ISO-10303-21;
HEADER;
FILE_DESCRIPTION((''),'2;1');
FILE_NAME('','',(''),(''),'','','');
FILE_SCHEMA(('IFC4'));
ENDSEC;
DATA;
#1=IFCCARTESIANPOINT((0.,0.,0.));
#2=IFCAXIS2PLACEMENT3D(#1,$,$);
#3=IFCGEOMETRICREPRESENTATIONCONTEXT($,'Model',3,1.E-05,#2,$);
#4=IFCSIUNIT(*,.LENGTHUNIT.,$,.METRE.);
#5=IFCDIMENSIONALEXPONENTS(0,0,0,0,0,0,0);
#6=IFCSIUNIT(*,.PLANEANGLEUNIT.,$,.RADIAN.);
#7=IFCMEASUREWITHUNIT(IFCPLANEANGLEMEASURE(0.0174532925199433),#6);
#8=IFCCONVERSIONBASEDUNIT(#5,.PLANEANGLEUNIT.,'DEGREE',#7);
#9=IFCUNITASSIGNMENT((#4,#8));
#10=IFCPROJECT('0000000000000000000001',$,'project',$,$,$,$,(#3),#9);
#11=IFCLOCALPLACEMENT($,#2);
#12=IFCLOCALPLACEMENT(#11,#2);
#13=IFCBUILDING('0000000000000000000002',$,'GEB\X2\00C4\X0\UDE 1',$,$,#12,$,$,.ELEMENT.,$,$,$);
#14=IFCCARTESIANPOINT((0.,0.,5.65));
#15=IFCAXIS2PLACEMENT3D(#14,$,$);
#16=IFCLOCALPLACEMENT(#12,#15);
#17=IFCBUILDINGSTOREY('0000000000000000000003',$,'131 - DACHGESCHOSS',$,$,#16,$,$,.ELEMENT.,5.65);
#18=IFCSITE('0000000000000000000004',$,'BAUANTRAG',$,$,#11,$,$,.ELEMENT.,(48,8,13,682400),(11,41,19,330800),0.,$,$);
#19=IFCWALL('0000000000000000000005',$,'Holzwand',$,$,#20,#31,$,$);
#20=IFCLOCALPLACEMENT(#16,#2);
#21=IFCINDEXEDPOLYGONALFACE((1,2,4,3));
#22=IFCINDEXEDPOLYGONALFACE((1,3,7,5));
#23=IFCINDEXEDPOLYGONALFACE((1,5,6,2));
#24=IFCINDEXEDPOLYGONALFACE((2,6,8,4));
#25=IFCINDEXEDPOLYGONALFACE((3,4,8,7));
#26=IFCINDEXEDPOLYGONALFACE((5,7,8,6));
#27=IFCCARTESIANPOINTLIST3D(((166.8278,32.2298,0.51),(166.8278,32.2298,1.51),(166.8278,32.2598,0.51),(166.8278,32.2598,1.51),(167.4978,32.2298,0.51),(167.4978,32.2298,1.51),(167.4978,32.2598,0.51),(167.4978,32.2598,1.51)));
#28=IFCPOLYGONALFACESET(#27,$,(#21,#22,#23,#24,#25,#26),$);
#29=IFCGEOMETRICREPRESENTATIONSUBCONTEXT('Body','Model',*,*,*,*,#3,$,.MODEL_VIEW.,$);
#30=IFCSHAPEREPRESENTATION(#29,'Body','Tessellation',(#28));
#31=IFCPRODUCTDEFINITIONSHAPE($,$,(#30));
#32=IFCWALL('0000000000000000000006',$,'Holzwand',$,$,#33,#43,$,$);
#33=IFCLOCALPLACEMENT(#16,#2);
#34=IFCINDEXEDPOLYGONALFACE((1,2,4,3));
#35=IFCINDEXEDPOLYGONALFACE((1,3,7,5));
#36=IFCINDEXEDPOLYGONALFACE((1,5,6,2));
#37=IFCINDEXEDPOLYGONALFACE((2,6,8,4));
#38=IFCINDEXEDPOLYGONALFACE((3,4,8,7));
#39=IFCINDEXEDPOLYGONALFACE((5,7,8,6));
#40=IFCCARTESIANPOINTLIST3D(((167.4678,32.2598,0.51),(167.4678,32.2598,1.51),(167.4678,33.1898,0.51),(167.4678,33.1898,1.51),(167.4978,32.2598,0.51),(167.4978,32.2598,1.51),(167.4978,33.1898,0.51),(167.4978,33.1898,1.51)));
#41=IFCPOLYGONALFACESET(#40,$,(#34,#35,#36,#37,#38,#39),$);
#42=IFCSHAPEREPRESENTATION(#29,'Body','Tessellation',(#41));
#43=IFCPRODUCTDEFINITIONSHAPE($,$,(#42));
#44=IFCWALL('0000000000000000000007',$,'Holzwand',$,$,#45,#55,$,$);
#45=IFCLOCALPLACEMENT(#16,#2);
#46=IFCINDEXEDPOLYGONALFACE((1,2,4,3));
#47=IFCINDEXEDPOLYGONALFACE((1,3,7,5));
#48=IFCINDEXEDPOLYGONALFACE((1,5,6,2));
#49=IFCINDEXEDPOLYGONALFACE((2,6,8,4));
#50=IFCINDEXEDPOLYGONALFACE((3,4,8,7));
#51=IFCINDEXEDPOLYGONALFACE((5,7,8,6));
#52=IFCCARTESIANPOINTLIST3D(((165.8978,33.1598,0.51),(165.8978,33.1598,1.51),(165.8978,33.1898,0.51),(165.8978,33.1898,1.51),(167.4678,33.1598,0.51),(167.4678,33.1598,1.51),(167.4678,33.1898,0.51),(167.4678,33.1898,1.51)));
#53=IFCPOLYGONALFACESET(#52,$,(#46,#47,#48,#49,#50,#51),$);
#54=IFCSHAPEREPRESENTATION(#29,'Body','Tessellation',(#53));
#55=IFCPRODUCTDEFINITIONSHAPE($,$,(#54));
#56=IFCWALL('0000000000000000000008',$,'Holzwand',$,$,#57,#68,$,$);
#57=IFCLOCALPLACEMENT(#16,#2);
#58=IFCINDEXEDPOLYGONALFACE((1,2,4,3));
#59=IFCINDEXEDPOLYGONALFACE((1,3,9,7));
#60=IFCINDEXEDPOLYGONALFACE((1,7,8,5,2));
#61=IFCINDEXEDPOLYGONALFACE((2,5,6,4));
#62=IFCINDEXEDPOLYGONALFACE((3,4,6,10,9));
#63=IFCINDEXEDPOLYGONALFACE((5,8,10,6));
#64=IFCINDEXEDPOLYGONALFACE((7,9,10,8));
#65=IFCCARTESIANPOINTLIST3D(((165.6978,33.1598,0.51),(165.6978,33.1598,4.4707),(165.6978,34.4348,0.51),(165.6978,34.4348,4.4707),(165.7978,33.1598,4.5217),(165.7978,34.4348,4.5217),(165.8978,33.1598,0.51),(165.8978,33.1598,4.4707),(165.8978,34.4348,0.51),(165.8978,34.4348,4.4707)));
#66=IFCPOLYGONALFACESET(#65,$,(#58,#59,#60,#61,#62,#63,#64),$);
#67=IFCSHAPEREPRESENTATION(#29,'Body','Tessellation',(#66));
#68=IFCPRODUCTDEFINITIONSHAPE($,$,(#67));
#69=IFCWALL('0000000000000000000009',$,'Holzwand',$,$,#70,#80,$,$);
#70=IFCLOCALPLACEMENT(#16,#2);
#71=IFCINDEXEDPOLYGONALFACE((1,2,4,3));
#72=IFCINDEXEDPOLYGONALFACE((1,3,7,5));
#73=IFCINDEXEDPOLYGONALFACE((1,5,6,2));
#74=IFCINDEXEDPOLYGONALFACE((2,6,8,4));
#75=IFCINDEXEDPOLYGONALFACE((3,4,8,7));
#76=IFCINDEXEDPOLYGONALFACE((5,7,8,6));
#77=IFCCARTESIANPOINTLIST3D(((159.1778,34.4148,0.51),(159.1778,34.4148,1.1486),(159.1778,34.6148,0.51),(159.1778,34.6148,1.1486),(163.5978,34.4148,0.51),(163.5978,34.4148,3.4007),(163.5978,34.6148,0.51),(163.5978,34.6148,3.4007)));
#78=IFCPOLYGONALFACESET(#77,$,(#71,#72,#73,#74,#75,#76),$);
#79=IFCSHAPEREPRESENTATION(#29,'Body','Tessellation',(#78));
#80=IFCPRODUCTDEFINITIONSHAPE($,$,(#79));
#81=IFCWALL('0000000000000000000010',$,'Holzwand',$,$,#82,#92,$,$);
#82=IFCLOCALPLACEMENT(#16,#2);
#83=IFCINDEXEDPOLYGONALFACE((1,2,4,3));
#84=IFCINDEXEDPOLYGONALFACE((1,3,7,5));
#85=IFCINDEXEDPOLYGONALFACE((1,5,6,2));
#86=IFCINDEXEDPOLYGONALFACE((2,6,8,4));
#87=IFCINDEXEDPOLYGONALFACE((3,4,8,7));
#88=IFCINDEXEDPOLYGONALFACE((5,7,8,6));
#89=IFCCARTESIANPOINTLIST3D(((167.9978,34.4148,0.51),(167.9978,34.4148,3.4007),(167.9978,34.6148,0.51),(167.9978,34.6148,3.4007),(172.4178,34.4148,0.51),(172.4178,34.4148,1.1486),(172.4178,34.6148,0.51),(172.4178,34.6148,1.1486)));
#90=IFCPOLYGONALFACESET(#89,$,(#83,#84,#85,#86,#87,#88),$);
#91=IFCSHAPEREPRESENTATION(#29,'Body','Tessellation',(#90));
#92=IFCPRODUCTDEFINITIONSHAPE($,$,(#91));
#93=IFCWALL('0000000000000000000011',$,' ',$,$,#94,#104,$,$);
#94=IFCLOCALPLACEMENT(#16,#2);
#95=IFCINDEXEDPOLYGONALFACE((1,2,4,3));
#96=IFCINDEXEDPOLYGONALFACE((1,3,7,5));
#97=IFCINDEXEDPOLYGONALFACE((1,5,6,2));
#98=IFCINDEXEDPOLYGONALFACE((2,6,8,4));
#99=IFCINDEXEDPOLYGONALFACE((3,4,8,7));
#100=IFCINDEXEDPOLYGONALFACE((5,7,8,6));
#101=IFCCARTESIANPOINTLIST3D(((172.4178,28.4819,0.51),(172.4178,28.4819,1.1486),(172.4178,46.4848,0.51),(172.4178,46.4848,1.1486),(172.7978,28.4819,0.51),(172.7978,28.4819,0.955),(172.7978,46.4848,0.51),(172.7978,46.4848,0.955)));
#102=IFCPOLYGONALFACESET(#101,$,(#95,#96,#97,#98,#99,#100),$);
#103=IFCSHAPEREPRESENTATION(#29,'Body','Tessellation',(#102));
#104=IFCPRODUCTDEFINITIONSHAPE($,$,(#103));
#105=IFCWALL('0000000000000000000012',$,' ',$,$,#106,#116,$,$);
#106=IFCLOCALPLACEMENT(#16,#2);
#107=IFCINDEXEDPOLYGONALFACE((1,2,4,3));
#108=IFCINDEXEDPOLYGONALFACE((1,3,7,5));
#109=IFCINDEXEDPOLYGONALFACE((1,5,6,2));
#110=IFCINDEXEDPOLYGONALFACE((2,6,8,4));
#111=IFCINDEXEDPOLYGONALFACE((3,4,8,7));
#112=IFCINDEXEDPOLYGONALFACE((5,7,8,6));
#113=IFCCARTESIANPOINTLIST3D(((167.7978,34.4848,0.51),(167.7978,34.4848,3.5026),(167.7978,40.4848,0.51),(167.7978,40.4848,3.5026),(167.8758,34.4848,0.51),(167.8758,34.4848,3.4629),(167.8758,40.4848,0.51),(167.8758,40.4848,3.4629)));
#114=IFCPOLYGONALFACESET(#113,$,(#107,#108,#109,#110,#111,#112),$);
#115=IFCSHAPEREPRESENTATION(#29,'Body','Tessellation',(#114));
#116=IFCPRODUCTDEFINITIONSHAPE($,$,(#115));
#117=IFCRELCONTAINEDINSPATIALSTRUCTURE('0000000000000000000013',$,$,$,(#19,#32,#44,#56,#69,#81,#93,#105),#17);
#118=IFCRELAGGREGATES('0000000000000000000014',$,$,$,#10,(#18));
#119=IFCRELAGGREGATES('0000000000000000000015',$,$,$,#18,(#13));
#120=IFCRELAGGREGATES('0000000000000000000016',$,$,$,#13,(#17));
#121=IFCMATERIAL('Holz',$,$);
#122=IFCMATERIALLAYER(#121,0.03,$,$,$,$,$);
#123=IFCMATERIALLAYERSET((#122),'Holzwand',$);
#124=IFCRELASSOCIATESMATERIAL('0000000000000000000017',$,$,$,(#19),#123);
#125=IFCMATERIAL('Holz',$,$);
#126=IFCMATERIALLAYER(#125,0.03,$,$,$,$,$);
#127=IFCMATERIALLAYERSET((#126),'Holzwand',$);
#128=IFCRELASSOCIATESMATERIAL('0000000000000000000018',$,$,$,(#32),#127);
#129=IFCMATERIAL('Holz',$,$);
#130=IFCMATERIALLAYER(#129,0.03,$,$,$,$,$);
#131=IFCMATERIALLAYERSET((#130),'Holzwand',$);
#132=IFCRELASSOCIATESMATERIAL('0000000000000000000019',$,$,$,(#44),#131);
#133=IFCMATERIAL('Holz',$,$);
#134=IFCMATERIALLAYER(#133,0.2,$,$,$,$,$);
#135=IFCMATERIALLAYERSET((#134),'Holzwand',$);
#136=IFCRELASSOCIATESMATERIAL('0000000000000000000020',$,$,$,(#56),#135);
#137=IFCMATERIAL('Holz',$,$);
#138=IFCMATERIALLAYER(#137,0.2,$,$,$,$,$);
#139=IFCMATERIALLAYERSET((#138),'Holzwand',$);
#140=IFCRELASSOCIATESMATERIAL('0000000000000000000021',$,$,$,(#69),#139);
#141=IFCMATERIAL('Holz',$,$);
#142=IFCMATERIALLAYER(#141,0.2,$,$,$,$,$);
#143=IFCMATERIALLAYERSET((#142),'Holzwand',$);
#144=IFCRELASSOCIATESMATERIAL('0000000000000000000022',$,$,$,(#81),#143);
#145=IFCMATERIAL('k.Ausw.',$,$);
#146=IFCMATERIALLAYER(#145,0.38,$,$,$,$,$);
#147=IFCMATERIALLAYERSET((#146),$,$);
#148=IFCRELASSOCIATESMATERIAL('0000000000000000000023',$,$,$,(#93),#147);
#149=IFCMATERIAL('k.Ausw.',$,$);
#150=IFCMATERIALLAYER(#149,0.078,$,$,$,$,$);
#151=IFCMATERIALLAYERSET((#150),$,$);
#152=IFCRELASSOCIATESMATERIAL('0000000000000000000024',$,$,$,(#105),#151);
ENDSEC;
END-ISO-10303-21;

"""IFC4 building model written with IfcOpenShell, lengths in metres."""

from ifc_helpers import new_model, entity, si_unit, converted_unit, frame, frame_2d, origin, origin_with_axes, place, context, subcontext, project, spatial, polyline, rectangle, extrude, clip, halfspace, bounded_halfspace, material, layer, layer_set, layer_usage, element, save


model = new_model("IFC4")

# Units and contexts
model_context = context("Model", 3, precision=1e-05, world=origin())
body_context = subcontext(model_context, "Body", "Model", "MODEL_VIEW")
ifc_project = project(units=[si_unit("LENGTHUNIT", "METRE"), converted_unit("PLANEANGLEUNIT", "DEGREE", entity("IfcPlaneAngleMeasure", 0.0174532925199433), si_unit("PLANEANGLEUNIT", "RADIAN"), dimensions=[0, 0, 0, 0, 0, 0, 0])], contexts=[model_context])

# Site, building, storey
site_placement = place(None, origin())
site = spatial("IfcSite", under=ifc_project, at=site_placement, Name="BAUANTRAG", CompositionType="ELEMENT", RefLatitude=(48, 8, 13, 682400), RefLongitude=(11, 41, 19, 330800), RefElevation=0.0)
building_placement = place(site_placement, origin())
building = spatial("IfcBuilding", under=site, at=building_placement, Name="GEBÄUDE 1", CompositionType="ELEMENT")
storey_placement = place(building_placement, frame((0.0, 0.0, 5.65)))
storey = spatial("IfcBuildingStorey", under=building, at=storey_placement, Name="131 - DACHGESCHOSS", CompositionType="ELEMENT", Elevation=5.65)

# Walls
ifc_material_1 = material(Name="Holz")
ifc_layer_1 = layer(ifc_material_1, 0.03)
ifc_layer_set_1 = layer_set([ifc_layer_1], Name="Holzwand")
ifc_layer_usage_1 = layer_usage(ifc_layer_set_1, "AXIS2", "POSITIVE", 0.0)
wall_1_placement = place(storey_placement, frame((167.4978, 32.2598, 0.51), z_axis=(0.0, 0.0, 1.0), x_axis=(-1.0, 0.0, 0.0)))
element("IfcWall", 1, at=wall_1_placement, inside=storey, material=ifc_layer_usage_1, Name="Holzwand", context=body_context, shape_type="SweptSolid", body=[
    extrude(rectangle(XDim=0.67, YDim=0.03, at=frame_2d((0.335, 0.015), x_axis=(1.0, 0.0))), origin_with_axes(), (0.0, 0.0, 1.0), 1.0),
])
ifc_material_2 = material(Name="Holz")
ifc_layer_2 = layer(ifc_material_2, 0.03)
ifc_layer_set_2 = layer_set([ifc_layer_2], Name="Holzwand")
ifc_layer_usage_2 = layer_usage(ifc_layer_set_2, "AXIS2", "POSITIVE", 0.0)
wall_2_placement = place(storey_placement, frame((167.4678, 33.1898, 0.51), z_axis=(0.0, 0.0, 1.0), x_axis=(0.0, -1.0, 0.0)))
element("IfcWall", 2, at=wall_2_placement, inside=storey, material=ifc_layer_usage_2, Name="Holzwand", context=body_context, shape_type="SweptSolid", body=[
    extrude(rectangle(XDim=0.93, YDim=0.03, at=frame_2d((0.465, 0.015), x_axis=(1.0, 0.0))), origin_with_axes(), (0.0, 0.0, 1.0), 1.0),
])
ifc_material_3 = material(Name="Holz")
ifc_layer_3 = layer(ifc_material_3, 0.03)
ifc_layer_set_3 = layer_set([ifc_layer_3], Name="Holzwand")
ifc_layer_usage_3 = layer_usage(ifc_layer_set_3, "AXIS2", "POSITIVE", 0.0)
wall_3_placement = place(storey_placement, frame((165.8978, 33.1598, 0.51)))
element("IfcWall", 3, at=wall_3_placement, inside=storey, material=ifc_layer_usage_3, Name="Holzwand", context=body_context, shape_type="SweptSolid", body=[
    extrude(rectangle(XDim=1.57, YDim=0.03, at=frame_2d((0.785, 0.015), x_axis=(1.0, 0.0))), origin_with_axes(), (0.0, 0.0, 1.0), 1.0),
])
ifc_material_4 = material(Name="Holz")
ifc_layer_4 = layer(ifc_material_4, 0.2)
ifc_layer_set_4 = layer_set([ifc_layer_4], Name="Holzwand")
ifc_layer_usage_4 = layer_usage(ifc_layer_set_4, "AXIS2", "POSITIVE", 0.0)
wall_4_placement = place(storey_placement, frame((165.6978, 34.4348, 0.51), z_axis=(0.0, 0.0, 1.0), x_axis=(0.0, -1.0, 0.0)))
element("IfcWall", 4, at=wall_4_placement, inside=storey, material=ifc_layer_usage_4, Name="Holzwand", context=body_context, shape_type="Clipping", body=[
    clip(clip(extrude(rectangle(XDim=1.275, YDim=0.2, at=frame_2d((0.6375, 0.1), x_axis=(1.0, 0.0))), origin_with_axes(), (0.0, 0.0, 1.0), 4.0117), bounded_halfspace(frame((0.6375, 0.05, 3.9862), z_axis=(0.0, 0.45399, -0.891007), x_axis=(0.0, 0.891007, 0.45399)), True, origin_with_axes(), polyline([(1.275, 0.0), (1.275, 0.1), (0.0, 0.1), (0.0, 0.0), (1.275, 0.0)]))), bounded_halfspace(frame((0.6375, 0.15, 3.9862), z_axis=(0.0, -0.45399, -0.891007), x_axis=(0.0, -0.891007, 0.45399)), True, origin_with_axes(), polyline([(0.0, 0.2), (0.0, 0.1), (1.275, 0.1), (1.275, 0.2), (0.0, 0.2)]))),
])
ifc_material_5 = material(Name="Holz")
ifc_layer_5 = layer(ifc_material_5, 0.2)
ifc_layer_set_5 = layer_set([ifc_layer_5], Name="Holzwand")
ifc_layer_usage_5 = layer_usage(ifc_layer_set_5, "AXIS2", "POSITIVE", 0.0)
wall_5_placement = place(storey_placement, frame((159.1778, 34.4148, 0.51)))
element("IfcWall", 5, at=wall_5_placement, inside=storey, material=ifc_layer_usage_5, Name="Holzwand", context=body_context, shape_type="Clipping", body=[
    clip(extrude(rectangle(XDim=4.42, YDim=0.2, at=frame_2d((2.21, 0.1), x_axis=(1.0, 0.0))), origin_with_axes(), (0.0, 0.0, 1.0), 2.8907), halfspace(frame((2.21, 0.1, 1.7647), z_axis=(0.45399, 0.0, -0.891007), x_axis=(0.891007, 0.0, 0.45399)), True)),
])
ifc_material_6 = material(Name="Holz")
ifc_layer_6 = layer(ifc_material_6, 0.2)
ifc_layer_set_6 = layer_set([ifc_layer_6], Name="Holzwand")
ifc_layer_usage_6 = layer_usage(ifc_layer_set_6, "AXIS2", "POSITIVE", 0.0)
wall_6_placement = place(storey_placement, frame((167.9978, 34.4148, 0.51)))
element("IfcWall", 6, at=wall_6_placement, inside=storey, material=ifc_layer_usage_6, Name="Holzwand", context=body_context, shape_type="Clipping", body=[
    clip(extrude(rectangle(XDim=4.42, YDim=0.2, at=frame_2d((2.21, 0.1), x_axis=(1.0, 0.0))), origin_with_axes(), (0.0, 0.0, 1.0), 2.8907), halfspace(frame((2.21, 0.1, 1.7647), z_axis=(-0.45399, 0.0, -0.891007), x_axis=(0.891007, 0.0, -0.45399)), True)),
])
ifc_material_7 = material(Name="k.Ausw.")
ifc_layer_7 = layer(ifc_material_7, 0.38)
ifc_layer_set_7 = layer_set([ifc_layer_7])
ifc_layer_usage_7 = layer_usage(ifc_layer_set_7, "AXIS2", "POSITIVE", 0.0)
wall_7_placement = place(storey_placement, frame((172.7978, 28.4819, 0.51), z_axis=(0.0, 0.0, 1.0), x_axis=(0.0, 1.0, 0.0)))
element("IfcWall", 7, at=wall_7_placement, inside=storey, material=ifc_layer_usage_7, Name=" ", context=body_context, shape_type="Clipping", body=[
    clip(extrude(rectangle(XDim=18.0029, YDim=0.38, at=frame_2d((9.0014, 0.19), x_axis=(1.0, 0.0))), origin_with_axes(), (0.0, 0.0, 1.0), 0.6386), halfspace(frame((9.0014, 0.19, 0.5418), z_axis=(0.0, 0.45399, -0.891007), x_axis=(0.0, -0.891007, -0.45399)), True)),
])
ifc_material_8 = material(Name="k.Ausw.")
ifc_layer_8 = layer(ifc_material_8, 0.078)
ifc_layer_set_8 = layer_set([ifc_layer_8])
ifc_layer_usage_8 = layer_usage(ifc_layer_set_8, "AXIS2", "POSITIVE", -0.078)
wall_8_placement = place(storey_placement, frame((167.8758, 34.4848, 0.51), z_axis=(0.0, 0.0, 1.0), x_axis=(0.0, 1.0, 0.0)))
element("IfcWall", 8, at=wall_8_placement, inside=storey, material=ifc_layer_usage_8, Name=" ", context=body_context, shape_type="Clipping", body=[
    clip(extrude(rectangle(XDim=6.0, YDim=0.078, at=frame_2d((3.0, 0.039), x_axis=(1.0, 0.0))), origin_with_axes(), (0.0, 0.0, 1.0), 2.9926), halfspace(frame((3.0, 0.039, 2.9728), z_axis=(0.0, 0.45399, -0.891007), x_axis=(1.0, 0.0, 0.0)), True)),
])

save(model, "model.ifc")
